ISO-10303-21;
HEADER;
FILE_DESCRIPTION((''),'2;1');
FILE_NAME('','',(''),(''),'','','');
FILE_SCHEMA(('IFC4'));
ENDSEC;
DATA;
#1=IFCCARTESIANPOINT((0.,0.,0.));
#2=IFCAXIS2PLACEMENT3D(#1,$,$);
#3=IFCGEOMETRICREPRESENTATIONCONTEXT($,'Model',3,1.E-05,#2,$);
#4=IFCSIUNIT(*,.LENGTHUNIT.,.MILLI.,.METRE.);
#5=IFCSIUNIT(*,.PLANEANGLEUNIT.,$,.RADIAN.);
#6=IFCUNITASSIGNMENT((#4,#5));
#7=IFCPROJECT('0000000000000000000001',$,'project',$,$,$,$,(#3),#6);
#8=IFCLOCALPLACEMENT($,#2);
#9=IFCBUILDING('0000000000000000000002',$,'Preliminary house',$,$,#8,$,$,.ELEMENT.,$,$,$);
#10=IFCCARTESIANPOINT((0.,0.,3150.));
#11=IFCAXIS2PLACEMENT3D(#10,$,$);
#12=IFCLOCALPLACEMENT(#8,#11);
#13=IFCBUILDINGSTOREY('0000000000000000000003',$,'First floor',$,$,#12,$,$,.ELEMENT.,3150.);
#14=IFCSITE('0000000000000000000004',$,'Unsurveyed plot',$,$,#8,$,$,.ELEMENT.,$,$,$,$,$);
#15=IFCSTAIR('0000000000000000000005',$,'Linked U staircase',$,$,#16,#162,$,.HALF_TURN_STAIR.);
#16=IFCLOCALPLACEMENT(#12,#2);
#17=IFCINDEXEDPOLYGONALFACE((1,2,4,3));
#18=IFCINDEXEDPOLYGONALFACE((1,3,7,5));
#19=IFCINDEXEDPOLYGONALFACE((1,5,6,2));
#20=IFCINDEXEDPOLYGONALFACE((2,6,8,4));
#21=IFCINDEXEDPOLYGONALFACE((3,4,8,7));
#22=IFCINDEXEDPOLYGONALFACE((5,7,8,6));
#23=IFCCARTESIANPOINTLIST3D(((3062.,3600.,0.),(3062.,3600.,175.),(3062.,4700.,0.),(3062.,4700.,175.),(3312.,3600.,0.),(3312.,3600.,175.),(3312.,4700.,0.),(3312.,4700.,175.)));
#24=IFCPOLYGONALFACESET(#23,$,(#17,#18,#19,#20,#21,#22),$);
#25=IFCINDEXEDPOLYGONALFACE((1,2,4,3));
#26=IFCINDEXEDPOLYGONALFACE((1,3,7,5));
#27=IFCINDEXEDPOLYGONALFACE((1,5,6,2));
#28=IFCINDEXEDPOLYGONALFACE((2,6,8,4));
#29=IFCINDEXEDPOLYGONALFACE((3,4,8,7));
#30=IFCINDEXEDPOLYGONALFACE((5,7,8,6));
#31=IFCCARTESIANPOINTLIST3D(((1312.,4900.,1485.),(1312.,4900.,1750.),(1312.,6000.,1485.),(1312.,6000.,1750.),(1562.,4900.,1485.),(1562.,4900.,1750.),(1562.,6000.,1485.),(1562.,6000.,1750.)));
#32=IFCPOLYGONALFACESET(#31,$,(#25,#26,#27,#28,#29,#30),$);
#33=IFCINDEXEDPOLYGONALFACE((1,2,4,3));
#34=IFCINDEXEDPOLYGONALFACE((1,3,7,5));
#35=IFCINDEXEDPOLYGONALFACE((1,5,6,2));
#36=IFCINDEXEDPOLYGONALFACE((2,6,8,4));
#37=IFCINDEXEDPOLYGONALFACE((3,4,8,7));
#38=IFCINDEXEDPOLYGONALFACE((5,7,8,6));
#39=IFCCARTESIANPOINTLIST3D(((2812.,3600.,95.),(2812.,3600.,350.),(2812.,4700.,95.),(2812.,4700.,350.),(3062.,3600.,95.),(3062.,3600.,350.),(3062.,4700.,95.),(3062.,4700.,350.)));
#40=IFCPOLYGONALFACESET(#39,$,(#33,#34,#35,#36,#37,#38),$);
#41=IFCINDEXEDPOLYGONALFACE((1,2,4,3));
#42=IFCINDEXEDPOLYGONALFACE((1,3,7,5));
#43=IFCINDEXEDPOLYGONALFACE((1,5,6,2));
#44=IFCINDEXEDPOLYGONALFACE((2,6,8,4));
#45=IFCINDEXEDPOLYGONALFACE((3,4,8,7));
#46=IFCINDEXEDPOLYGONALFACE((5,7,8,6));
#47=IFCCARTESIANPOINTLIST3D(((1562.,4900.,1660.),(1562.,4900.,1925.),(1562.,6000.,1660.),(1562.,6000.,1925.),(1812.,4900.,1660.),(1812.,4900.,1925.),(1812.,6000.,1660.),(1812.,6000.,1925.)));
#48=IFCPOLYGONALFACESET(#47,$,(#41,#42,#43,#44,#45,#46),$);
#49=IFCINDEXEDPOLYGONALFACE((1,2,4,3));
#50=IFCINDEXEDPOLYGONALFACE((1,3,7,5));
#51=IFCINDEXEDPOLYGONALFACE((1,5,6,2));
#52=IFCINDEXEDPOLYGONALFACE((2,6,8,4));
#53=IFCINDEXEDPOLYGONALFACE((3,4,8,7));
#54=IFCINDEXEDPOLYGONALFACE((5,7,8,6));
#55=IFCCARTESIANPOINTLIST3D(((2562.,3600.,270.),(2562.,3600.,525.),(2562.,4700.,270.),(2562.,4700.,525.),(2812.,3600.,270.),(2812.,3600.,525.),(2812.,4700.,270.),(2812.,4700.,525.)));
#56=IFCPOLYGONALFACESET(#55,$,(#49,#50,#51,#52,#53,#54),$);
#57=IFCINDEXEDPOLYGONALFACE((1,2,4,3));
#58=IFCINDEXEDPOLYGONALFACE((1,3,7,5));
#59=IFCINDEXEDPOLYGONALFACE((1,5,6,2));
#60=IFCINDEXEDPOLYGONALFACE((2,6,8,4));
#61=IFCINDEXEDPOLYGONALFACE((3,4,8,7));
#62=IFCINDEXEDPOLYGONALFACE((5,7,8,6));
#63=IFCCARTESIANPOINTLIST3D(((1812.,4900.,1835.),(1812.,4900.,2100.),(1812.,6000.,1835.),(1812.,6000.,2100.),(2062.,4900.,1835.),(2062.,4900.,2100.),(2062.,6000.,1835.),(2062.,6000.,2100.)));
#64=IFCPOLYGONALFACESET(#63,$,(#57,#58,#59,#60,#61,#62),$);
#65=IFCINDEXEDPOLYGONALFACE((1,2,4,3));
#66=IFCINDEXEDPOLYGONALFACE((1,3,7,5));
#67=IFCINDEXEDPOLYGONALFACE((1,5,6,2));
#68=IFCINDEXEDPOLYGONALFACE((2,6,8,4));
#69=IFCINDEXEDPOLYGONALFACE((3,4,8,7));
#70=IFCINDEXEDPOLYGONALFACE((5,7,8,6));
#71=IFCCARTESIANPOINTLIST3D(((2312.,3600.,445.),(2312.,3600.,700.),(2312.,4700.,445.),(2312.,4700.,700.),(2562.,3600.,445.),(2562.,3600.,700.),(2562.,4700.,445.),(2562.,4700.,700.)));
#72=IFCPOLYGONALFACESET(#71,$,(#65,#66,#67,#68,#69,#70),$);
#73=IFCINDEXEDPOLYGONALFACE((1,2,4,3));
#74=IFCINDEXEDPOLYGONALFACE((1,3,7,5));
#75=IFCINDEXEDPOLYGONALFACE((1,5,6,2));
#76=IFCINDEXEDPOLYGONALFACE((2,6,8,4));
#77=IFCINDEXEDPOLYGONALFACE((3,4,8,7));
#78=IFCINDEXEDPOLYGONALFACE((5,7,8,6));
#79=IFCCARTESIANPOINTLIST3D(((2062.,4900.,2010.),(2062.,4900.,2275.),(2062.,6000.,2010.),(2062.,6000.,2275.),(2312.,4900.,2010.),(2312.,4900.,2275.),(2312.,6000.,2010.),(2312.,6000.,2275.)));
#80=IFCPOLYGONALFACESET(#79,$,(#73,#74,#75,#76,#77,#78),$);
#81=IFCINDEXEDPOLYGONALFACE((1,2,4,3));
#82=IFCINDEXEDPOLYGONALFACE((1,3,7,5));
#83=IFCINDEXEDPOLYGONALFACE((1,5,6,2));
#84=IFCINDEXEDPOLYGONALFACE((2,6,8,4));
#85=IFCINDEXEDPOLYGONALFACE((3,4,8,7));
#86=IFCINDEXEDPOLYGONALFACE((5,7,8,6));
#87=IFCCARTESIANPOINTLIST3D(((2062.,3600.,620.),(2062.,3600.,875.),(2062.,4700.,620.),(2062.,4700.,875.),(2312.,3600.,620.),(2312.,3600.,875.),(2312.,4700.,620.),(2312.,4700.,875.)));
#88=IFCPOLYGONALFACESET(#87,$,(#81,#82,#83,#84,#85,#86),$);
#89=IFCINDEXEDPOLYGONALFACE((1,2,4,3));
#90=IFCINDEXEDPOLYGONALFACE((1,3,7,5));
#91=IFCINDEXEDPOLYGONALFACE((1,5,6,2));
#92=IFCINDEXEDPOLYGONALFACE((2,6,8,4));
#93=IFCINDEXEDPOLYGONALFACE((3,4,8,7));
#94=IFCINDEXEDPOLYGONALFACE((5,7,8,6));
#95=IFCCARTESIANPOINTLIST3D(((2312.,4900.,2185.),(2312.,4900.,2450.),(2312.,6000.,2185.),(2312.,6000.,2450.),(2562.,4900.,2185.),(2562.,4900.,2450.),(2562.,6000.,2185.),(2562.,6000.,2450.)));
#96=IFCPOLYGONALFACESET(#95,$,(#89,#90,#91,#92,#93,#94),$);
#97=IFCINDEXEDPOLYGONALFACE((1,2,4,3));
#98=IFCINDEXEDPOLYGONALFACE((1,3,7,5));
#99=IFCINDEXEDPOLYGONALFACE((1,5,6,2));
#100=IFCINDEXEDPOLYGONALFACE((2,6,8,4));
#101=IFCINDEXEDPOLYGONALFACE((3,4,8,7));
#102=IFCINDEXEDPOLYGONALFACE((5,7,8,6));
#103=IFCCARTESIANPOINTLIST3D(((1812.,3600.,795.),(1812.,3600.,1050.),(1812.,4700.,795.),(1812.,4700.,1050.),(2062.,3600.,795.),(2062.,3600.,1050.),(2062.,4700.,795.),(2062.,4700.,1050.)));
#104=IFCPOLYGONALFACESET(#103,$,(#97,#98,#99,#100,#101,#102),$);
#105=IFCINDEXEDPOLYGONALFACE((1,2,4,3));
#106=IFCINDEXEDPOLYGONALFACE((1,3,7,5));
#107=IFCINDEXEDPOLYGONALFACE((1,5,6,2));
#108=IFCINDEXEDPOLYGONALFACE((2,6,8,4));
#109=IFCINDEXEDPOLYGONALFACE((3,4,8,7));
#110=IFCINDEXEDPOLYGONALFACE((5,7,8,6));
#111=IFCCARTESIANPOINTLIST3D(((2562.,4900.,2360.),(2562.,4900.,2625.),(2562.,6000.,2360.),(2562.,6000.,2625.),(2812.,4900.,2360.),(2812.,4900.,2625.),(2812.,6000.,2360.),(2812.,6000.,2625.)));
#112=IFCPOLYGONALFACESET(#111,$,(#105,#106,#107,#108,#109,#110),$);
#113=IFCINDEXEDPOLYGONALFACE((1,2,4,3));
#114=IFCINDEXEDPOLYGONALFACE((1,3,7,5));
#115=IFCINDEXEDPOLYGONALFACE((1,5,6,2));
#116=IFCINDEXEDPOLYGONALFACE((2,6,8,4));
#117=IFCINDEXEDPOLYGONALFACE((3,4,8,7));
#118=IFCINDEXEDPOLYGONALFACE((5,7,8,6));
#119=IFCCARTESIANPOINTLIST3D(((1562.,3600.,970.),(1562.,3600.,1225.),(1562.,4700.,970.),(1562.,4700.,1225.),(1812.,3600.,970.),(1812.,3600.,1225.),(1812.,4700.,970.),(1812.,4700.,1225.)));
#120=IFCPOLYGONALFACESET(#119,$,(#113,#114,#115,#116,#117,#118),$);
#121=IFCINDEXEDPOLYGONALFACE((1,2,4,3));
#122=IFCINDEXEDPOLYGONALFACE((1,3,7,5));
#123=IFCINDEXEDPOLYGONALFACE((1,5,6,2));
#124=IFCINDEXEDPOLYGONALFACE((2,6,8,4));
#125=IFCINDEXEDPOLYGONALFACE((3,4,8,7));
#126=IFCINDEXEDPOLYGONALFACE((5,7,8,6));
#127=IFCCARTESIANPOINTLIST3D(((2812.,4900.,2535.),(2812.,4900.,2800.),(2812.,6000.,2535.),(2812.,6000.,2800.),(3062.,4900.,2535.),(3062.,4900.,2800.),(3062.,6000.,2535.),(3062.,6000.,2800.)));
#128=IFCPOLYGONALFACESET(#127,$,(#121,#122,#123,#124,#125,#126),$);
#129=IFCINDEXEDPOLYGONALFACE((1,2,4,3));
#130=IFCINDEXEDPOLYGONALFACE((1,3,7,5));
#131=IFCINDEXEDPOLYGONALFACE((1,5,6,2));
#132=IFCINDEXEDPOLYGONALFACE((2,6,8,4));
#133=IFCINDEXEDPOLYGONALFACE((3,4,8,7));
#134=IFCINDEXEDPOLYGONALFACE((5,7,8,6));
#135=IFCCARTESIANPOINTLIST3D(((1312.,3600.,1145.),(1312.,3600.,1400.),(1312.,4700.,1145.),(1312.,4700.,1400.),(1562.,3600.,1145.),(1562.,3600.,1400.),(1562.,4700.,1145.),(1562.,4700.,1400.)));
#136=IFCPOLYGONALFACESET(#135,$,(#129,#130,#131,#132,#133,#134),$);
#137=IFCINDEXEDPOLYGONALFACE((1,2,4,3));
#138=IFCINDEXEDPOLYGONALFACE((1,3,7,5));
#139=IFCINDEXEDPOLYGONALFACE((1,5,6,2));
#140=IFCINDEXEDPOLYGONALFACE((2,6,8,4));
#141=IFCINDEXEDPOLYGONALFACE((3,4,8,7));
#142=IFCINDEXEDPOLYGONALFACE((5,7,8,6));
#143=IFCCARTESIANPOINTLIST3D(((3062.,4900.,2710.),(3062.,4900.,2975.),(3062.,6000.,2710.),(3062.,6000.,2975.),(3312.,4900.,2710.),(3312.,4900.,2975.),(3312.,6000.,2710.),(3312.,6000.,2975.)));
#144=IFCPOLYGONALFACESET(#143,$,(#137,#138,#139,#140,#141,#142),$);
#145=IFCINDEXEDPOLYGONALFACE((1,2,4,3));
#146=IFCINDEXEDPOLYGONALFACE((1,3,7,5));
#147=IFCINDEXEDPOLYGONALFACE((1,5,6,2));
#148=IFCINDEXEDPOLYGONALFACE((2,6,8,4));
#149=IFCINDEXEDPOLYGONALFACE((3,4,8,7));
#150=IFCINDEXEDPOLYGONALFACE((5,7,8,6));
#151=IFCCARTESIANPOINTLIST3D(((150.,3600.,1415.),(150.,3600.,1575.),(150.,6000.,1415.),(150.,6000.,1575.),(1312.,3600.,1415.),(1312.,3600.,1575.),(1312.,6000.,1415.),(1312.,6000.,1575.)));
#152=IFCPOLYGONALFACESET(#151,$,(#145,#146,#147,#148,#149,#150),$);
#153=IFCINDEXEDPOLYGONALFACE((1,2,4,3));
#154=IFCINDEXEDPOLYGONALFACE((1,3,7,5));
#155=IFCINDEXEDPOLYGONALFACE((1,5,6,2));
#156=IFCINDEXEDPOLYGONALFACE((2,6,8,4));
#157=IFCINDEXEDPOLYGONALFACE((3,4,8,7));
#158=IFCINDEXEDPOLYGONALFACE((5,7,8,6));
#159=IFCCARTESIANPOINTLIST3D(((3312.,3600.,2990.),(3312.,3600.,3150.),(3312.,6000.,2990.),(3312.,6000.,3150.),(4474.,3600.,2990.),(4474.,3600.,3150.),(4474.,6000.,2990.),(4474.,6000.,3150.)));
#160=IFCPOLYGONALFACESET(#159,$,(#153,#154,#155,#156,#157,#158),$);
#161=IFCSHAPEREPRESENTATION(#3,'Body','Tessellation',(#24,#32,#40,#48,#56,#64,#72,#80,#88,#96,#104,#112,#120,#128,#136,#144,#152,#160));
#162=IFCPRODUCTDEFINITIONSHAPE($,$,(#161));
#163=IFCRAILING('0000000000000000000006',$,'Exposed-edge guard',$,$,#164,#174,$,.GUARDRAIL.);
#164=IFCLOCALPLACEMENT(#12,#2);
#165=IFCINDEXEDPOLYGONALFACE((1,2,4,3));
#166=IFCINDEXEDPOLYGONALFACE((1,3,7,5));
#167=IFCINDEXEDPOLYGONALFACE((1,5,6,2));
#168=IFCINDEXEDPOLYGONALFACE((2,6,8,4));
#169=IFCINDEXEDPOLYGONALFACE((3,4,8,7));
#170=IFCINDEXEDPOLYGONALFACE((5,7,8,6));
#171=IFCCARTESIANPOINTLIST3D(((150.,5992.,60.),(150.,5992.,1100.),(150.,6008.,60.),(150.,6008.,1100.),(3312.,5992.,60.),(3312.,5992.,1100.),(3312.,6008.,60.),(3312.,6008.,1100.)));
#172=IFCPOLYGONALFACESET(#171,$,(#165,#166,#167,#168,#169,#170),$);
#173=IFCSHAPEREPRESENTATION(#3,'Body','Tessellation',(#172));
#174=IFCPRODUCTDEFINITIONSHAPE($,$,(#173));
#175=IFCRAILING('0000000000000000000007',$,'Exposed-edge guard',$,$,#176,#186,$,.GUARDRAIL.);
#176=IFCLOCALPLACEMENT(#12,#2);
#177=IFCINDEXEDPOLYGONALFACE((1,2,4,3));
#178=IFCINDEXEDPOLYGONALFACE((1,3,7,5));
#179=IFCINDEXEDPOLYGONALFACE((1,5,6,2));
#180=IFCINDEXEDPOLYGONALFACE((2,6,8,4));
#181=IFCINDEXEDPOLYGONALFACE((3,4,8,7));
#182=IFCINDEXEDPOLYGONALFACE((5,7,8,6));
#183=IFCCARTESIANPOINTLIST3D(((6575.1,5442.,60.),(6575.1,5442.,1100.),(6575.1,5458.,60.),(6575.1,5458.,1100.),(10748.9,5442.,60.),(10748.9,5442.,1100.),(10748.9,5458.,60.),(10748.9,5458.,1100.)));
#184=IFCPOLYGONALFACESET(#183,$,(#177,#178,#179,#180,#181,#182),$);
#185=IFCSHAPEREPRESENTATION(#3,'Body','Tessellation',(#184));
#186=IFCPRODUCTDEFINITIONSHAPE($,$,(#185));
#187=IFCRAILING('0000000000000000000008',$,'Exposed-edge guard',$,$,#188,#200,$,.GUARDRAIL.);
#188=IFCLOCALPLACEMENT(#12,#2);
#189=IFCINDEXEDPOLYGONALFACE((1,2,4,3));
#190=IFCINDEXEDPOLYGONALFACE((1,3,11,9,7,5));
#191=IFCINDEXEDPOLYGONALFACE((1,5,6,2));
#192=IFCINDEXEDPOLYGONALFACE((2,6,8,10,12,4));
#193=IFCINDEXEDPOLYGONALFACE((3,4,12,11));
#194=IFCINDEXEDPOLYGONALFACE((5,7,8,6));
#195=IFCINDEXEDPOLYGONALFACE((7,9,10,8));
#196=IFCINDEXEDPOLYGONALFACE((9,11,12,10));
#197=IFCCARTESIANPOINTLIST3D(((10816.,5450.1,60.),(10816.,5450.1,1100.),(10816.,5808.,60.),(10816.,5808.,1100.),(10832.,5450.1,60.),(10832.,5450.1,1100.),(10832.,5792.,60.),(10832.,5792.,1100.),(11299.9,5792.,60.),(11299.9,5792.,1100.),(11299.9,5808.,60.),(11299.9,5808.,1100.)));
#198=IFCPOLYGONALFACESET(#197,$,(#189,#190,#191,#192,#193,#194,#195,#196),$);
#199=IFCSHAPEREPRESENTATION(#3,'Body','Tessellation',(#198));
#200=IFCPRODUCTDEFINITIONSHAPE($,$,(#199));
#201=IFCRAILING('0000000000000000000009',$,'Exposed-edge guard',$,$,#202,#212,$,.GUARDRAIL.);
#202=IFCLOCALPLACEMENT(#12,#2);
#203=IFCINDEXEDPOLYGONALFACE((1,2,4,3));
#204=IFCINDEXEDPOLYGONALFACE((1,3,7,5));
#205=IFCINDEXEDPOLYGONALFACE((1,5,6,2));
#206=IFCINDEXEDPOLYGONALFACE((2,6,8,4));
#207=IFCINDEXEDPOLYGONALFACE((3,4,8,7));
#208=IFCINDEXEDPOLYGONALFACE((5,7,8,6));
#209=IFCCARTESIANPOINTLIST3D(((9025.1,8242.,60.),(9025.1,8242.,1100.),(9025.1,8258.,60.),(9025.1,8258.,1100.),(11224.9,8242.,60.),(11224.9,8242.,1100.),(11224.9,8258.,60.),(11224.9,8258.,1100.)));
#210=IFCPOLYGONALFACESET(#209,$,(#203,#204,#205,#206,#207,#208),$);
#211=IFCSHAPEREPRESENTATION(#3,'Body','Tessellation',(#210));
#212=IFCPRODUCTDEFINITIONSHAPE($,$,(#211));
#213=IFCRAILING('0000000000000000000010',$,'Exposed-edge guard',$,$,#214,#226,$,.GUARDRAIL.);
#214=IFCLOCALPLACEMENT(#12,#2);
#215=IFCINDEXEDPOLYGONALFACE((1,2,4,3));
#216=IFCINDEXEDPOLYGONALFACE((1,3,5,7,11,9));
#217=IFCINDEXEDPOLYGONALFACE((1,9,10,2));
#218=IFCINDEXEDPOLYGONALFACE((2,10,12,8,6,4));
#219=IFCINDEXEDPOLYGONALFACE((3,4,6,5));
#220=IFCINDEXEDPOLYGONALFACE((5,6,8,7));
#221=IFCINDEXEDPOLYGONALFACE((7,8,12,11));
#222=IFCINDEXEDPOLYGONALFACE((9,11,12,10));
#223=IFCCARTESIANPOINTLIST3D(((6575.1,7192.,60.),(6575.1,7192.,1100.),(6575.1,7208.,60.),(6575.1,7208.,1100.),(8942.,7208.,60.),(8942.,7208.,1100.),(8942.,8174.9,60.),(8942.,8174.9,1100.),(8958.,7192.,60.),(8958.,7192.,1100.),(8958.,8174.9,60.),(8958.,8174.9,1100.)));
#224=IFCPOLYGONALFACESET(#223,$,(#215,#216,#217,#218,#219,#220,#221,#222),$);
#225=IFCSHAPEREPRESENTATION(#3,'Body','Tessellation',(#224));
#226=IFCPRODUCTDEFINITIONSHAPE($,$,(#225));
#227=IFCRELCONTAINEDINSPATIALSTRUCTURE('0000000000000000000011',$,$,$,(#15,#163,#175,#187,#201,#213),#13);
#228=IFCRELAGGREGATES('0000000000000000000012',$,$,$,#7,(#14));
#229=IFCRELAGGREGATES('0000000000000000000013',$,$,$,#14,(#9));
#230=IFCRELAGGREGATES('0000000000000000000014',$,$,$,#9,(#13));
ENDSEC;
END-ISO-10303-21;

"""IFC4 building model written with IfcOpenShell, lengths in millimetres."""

from ifc_helpers import new_model, si_unit, frame, origin, place, context, project, spatial, polyline, outline, extrude, element, save


model = new_model("IFC4")

# Units and contexts
model_context = context("Model", 3, precision=1e-05, world=origin())
ifc_project = project(units=[si_unit("LENGTHUNIT", "METRE", prefix="MILLI"), si_unit("PLANEANGLEUNIT", "RADIAN")], contexts=[model_context])

# Site, building, storey
placement_1 = place(None, origin())
site = spatial("IfcSite", under=ifc_project, at=placement_1, Name="Unsurveyed plot", CompositionType="ELEMENT")
building = spatial("IfcBuilding", under=site, at=placement_1, Name="Preliminary house", CompositionType="ELEMENT")
placement_2 = place(placement_1, frame((0.0, 0.0, 3150.0)))
storey = spatial("IfcBuildingStorey", under=building, at=placement_2, Name="First floor", CompositionType="ELEMENT", Elevation=3150.0)

# Stair
element("IfcStair", 1, at=placement_2, inside=storey, Name="Linked U staircase", PredefinedType="HALF_TURN_STAIR", context=model_context, shape_type="SweptSolid", body=[
    extrude(outline(polyline([(3312.0, 4700.0), (3062.0, 4700.0), (3062.0, 3600.0), (3312.0, 3600.0), (3312.0, 4700.0)])), origin(), (0.0, 0.0, 1.0), 175.0),
    extrude(outline(polyline([(1562.0, 6000.0), (1312.0, 6000.0), (1312.0, 4900.0), (1562.0, 4900.0), (1562.0, 6000.0)])), frame((0.0, 0.0, 1485.0)), (0.0, 0.0, 1.0), 265.0),
    extrude(outline(polyline([(3062.0, 4700.0), (2812.0, 4700.0), (2812.0, 3600.0), (3062.0, 3600.0), (3062.0, 4700.0)])), frame((0.0, 0.0, 95.0)), (0.0, 0.0, 1.0), 255.0),
    extrude(outline(polyline([(1812.0, 6000.0), (1562.0, 6000.0), (1562.0, 4900.0), (1812.0, 4900.0), (1812.0, 6000.0)])), frame((0.0, 0.0, 1660.0)), (0.0, 0.0, 1.0), 265.0),
    extrude(outline(polyline([(2812.0, 4700.0), (2562.0, 4700.0), (2562.0, 3600.0), (2812.0, 3600.0), (2812.0, 4700.0)])), frame((0.0, 0.0, 270.0)), (0.0, 0.0, 1.0), 255.0),
    extrude(outline(polyline([(2062.0, 6000.0), (1812.0, 6000.0), (1812.0, 4900.0), (2062.0, 4900.0), (2062.0, 6000.0)])), frame((0.0, 0.0, 1835.0)), (0.0, 0.0, 1.0), 265.0),
    extrude(outline(polyline([(2562.0, 4700.0), (2312.0, 4700.0), (2312.0, 3600.0), (2562.0, 3600.0), (2562.0, 4700.0)])), frame((0.0, 0.0, 445.0)), (0.0, 0.0, 1.0), 255.0),
    extrude(outline(polyline([(2312.0, 6000.0), (2062.0, 6000.0), (2062.0, 4900.0), (2312.0, 4900.0), (2312.0, 6000.0)])), frame((0.0, 0.0, 2010.0)), (0.0, 0.0, 1.0), 265.0),
    extrude(outline(polyline([(2312.0, 4700.0), (2062.0, 4700.0), (2062.0, 3600.0), (2312.0, 3600.0), (2312.0, 4700.0)])), frame((0.0, 0.0, 620.0)), (0.0, 0.0, 1.0), 255.0),
    extrude(outline(polyline([(2562.0, 6000.0), (2312.0, 6000.0), (2312.0, 4900.0), (2562.0, 4900.0), (2562.0, 6000.0)])), frame((0.0, 0.0, 2185.0)), (0.0, 0.0, 1.0), 265.0),
    extrude(outline(polyline([(2062.0, 4700.0), (1812.0, 4700.0), (1812.0, 3600.0), (2062.0, 3600.0), (2062.0, 4700.0)])), frame((0.0, 0.0, 795.0)), (0.0, 0.0, 1.0), 255.0),
    extrude(outline(polyline([(2812.0, 6000.0), (2562.0, 6000.0), (2562.0, 4900.0), (2812.0, 4900.0), (2812.0, 6000.0)])), frame((0.0, 0.0, 2360.0)), (0.0, 0.0, 1.0), 265.0),
    extrude(outline(polyline([(1812.0, 4700.0), (1562.0, 4700.0), (1562.0, 3600.0), (1812.0, 3600.0), (1812.0, 4700.0)])), frame((0.0, 0.0, 970.0)), (0.0, 0.0, 1.0), 255.0),
    extrude(outline(polyline([(3062.0, 6000.0), (2812.0, 6000.0), (2812.0, 4900.0), (3062.0, 4900.0), (3062.0, 6000.0)])), frame((0.0, 0.0, 2535.0)), (0.0, 0.0, 1.0), 265.0),
    extrude(outline(polyline([(1562.0, 4700.0), (1312.0, 4700.0), (1312.0, 3600.0), (1562.0, 3600.0), (1562.0, 4700.0)])), frame((0.0, 0.0, 1145.0)), (0.0, 0.0, 1.0), 255.0),
    extrude(outline(polyline([(3312.0, 6000.0), (3062.0, 6000.0), (3062.0, 4900.0), (3312.0, 4900.0), (3312.0, 6000.0)])), frame((0.0, 0.0, 2710.0)), (0.0, 0.0, 1.0), 265.0),
    extrude(outline(polyline([(1312.0, 6000.0), (150.0, 6000.0), (150.0, 3600.0), (1312.0, 3600.0), (1312.0, 6000.0)])), frame((0.0, 0.0, 1415.0)), (0.0, 0.0, 1.0), 160.0),
    extrude(outline(polyline([(4474.0, 6000.0), (3312.0, 6000.0), (3312.0, 3600.0), (4474.0, 3600.0), (4474.0, 6000.0)])), frame((0.0, 0.0, 2990.0)), (0.0, 0.0, 1.0), 160.0),
])

# Railings
element("IfcRailing", 2, at=placement_2, inside=storey, Name="Exposed-edge guard", PredefinedType="GUARDRAIL", context=model_context, shape_type="SweptSolid", body=[
    extrude(outline(polyline([(150.0, 5992.0), (150.0, 6008.0), (3312.0, 6008.0), (3312.0, 5992.0), (150.0, 5992.0)])), frame((0.0, 0.0, 60.0)), (0.0, 0.0, 1.0), 1040.0),
])
element("IfcRailing", 3, at=placement_2, inside=storey, Name="Exposed-edge guard", PredefinedType="GUARDRAIL", context=model_context, shape_type="SweptSolid", body=[
    extrude(outline(polyline([(10748.9, 5458.0), (10748.9, 5442.0), (6575.1, 5442.0), (6575.1, 5458.0), (10748.9, 5458.0)])), frame((0.0, 0.0, 60.0)), (0.0, 0.0, 1.0), 1040.0),
])
element("IfcRailing", 4, at=placement_2, inside=storey, Name="Exposed-edge guard", PredefinedType="GUARDRAIL", context=model_context, shape_type="SweptSolid", body=[
    extrude(outline(polyline([(10816.0, 5808.0), (11299.9, 5808.0), (11299.9, 5792.0), (10832.0, 5792.0), (10832.0, 5450.1), (10816.0, 5450.1), (10816.0, 5808.0)])), frame((0.0, 0.0, 60.0)), (0.0, 0.0, 1.0), 1040.0),
])
element("IfcRailing", 5, at=placement_2, inside=storey, Name="Exposed-edge guard", PredefinedType="GUARDRAIL", context=model_context, shape_type="SweptSolid", body=[
    extrude(outline(polyline([(9025.1, 8242.0), (9025.1, 8258.0), (11224.9, 8258.0), (11224.9, 8242.0), (9025.1, 8242.0)])), frame((0.0, 0.0, 60.0)), (0.0, 0.0, 1.0), 1040.0),
])
element("IfcRailing", 6, at=placement_2, inside=storey, Name="Exposed-edge guard", PredefinedType="GUARDRAIL", context=model_context, shape_type="SweptSolid", body=[
    extrude(outline(polyline([(8958.0, 7192.0), (6575.1, 7192.0), (6575.1, 7208.0), (8942.0, 7208.0), (8942.0, 8174.9), (8958.0, 8174.9), (8958.0, 7192.0)])), frame((0.0, 0.0, 60.0)), (0.0, 0.0, 1.0), 1040.0),
])

save(model, "model.ifc")
